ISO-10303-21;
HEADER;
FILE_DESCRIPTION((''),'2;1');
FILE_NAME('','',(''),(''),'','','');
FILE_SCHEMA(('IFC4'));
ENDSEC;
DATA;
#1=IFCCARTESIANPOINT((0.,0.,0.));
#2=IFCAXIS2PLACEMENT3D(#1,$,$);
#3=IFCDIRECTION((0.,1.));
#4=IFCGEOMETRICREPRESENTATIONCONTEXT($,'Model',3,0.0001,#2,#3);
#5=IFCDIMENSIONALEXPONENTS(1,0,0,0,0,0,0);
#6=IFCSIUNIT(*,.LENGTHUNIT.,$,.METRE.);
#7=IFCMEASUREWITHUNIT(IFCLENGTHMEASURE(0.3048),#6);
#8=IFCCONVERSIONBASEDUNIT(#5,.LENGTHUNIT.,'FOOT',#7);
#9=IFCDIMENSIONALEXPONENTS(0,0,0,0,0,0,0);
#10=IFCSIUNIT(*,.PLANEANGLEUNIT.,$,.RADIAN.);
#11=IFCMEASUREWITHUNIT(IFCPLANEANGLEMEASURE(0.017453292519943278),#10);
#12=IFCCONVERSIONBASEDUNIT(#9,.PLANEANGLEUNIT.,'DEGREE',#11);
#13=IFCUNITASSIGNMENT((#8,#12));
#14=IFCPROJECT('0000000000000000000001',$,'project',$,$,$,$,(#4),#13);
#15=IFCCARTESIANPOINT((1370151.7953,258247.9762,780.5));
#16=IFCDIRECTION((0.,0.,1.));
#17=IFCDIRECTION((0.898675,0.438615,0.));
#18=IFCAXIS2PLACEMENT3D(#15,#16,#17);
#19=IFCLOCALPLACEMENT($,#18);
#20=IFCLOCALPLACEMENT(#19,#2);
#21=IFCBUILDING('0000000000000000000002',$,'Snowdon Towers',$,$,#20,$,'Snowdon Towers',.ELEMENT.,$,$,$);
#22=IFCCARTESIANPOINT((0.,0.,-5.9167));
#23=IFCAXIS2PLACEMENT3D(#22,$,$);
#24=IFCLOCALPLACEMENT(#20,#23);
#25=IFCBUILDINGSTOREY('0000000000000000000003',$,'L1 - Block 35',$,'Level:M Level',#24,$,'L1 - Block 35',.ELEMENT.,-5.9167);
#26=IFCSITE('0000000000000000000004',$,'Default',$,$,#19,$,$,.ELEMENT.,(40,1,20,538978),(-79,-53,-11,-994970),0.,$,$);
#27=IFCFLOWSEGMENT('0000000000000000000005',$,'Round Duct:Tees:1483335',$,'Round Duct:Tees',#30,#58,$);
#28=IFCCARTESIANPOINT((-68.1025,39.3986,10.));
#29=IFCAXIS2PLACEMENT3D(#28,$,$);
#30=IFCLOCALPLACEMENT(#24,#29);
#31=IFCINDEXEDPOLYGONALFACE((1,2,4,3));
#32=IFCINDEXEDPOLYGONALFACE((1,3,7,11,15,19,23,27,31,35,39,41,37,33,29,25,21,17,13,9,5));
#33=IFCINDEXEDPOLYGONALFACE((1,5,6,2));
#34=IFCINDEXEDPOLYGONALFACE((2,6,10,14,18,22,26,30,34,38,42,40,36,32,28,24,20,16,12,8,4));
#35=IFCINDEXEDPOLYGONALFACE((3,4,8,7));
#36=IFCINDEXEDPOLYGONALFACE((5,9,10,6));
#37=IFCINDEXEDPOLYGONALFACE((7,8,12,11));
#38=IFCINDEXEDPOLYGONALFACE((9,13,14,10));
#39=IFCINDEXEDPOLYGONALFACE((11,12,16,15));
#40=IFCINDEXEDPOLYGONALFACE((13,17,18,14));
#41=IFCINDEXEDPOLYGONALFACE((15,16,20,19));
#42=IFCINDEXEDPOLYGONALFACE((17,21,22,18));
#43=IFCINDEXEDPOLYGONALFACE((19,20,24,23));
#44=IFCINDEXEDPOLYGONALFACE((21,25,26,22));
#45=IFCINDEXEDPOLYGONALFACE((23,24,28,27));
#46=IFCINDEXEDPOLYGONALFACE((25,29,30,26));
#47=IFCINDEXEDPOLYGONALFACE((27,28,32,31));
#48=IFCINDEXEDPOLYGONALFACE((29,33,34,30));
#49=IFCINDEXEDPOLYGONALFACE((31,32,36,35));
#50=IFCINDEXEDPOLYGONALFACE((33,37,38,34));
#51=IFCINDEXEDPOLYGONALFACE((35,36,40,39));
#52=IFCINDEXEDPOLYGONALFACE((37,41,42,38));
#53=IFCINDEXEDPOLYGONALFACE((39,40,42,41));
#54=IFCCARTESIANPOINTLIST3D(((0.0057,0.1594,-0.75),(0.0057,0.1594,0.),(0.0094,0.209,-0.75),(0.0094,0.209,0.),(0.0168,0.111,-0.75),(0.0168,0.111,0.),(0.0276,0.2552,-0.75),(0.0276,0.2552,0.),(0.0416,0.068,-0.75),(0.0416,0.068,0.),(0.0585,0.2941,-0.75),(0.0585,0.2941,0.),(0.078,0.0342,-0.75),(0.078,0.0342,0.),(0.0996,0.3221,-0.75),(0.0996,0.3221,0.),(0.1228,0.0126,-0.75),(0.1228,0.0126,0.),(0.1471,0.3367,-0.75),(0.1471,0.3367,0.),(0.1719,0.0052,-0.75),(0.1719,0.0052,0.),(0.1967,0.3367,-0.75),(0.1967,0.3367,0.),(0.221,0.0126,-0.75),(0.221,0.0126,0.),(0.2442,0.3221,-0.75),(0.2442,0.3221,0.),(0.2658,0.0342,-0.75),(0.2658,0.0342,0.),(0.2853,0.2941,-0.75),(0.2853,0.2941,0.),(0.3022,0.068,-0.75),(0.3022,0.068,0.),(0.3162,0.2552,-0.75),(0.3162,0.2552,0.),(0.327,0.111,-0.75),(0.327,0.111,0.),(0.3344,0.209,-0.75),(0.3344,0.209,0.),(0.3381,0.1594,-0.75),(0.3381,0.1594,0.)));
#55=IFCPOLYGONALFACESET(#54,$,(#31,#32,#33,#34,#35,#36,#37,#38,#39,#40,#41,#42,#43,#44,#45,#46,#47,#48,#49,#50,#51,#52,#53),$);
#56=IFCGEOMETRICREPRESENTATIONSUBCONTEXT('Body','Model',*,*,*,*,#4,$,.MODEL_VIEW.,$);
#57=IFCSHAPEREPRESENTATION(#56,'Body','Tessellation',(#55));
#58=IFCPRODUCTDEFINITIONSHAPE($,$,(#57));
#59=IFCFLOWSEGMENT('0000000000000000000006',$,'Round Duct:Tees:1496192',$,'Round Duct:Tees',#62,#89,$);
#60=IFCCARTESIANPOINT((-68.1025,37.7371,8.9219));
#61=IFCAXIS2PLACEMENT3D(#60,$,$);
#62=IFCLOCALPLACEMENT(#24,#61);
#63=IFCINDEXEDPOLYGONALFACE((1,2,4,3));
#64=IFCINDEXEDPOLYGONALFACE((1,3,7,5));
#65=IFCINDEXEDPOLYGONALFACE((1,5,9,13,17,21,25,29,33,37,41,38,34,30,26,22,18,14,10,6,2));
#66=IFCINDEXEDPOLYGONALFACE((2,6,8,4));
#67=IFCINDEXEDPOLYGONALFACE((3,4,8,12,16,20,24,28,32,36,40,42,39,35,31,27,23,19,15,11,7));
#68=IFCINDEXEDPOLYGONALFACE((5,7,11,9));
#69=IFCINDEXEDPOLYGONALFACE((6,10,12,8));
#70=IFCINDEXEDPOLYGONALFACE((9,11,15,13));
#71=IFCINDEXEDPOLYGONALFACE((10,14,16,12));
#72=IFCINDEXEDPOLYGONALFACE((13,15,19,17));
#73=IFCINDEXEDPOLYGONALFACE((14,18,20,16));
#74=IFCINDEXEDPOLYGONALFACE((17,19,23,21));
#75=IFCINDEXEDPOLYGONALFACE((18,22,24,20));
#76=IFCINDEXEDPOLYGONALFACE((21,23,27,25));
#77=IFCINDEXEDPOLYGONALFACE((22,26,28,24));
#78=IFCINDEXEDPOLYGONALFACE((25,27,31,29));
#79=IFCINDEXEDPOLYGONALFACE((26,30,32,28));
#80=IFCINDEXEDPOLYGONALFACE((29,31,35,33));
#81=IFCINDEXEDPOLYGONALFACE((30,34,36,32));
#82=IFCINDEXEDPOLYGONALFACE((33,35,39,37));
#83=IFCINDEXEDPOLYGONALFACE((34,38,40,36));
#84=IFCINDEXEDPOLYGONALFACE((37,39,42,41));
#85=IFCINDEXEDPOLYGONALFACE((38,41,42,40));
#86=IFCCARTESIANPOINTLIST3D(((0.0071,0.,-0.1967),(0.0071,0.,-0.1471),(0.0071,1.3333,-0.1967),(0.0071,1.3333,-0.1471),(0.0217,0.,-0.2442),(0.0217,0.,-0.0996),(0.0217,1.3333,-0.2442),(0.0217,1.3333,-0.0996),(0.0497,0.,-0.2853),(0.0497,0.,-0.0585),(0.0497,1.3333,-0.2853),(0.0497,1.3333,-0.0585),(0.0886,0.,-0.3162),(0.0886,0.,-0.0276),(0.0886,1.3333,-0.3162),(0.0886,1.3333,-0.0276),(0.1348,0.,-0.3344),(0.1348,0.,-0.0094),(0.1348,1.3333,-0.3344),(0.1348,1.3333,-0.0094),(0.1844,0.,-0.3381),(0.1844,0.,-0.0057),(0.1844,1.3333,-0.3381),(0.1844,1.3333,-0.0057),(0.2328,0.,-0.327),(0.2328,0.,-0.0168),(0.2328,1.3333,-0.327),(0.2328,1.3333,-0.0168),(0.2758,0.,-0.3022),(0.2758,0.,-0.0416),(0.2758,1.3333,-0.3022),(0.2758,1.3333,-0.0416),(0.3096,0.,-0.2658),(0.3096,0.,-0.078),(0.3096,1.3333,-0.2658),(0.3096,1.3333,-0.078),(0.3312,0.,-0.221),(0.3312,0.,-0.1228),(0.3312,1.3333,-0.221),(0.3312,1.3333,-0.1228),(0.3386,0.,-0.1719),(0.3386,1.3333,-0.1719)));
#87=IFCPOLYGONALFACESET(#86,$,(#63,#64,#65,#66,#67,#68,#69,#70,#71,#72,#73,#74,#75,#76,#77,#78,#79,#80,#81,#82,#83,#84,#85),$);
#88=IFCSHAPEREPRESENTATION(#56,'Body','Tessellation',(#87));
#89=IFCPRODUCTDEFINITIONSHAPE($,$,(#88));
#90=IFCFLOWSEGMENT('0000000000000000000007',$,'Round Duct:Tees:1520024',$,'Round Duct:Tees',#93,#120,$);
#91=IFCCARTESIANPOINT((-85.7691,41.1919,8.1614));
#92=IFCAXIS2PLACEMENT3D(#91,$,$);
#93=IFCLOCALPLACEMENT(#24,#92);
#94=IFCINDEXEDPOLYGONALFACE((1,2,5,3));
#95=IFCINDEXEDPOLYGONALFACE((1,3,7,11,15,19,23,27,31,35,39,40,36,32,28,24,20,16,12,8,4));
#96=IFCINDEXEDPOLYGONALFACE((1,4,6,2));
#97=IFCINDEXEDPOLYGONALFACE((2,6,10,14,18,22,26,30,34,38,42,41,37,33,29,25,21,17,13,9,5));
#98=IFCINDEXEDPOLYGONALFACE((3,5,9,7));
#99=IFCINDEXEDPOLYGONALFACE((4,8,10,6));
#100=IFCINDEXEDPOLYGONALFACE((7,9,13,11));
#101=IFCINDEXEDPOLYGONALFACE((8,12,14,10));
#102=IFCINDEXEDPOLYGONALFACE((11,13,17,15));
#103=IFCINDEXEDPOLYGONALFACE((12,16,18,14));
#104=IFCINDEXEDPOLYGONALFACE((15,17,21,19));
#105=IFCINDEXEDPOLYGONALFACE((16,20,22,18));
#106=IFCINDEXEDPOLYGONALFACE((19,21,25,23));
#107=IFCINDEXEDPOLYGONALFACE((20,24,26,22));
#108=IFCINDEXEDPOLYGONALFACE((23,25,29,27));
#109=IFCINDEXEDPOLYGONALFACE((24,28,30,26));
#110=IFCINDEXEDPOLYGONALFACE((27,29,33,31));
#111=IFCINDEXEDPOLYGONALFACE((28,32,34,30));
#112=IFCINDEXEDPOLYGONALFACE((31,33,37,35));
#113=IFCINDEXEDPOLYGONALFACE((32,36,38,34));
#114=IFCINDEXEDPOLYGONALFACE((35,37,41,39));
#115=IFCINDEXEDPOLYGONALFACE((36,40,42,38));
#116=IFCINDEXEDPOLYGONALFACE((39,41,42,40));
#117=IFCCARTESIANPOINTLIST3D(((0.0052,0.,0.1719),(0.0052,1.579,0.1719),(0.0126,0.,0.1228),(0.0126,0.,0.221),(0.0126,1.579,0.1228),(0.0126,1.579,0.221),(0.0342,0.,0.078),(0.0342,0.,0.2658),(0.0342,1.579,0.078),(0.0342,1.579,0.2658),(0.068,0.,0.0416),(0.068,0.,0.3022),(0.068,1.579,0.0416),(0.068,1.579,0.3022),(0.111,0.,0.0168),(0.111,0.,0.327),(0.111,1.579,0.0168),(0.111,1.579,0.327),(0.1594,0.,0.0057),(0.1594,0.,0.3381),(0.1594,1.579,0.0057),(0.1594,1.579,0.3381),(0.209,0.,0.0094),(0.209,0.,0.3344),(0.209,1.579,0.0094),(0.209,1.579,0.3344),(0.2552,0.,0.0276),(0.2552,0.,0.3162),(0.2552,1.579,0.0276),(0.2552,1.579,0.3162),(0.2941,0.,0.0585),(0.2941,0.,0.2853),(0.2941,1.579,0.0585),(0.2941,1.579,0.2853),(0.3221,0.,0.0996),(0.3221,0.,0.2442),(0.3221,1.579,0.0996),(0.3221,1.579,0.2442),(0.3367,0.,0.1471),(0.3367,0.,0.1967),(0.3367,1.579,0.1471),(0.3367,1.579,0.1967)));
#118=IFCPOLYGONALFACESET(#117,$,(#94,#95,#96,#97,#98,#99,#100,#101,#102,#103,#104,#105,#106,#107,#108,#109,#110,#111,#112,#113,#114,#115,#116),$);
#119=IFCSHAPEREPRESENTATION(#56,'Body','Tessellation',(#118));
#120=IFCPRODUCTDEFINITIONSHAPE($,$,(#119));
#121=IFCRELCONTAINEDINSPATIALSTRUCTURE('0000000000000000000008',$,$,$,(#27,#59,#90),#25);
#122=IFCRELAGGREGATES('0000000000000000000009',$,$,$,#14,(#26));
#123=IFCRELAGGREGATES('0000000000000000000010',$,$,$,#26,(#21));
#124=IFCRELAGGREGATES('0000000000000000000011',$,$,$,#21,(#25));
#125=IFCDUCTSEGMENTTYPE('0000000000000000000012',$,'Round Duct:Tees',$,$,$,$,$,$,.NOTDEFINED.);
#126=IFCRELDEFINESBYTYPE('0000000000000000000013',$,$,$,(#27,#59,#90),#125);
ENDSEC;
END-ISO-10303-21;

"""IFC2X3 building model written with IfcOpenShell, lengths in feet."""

from ifc_helpers import new_model, entity, si_unit, converted_unit, direction, frame, origin, origin_2d_with_axis, place, context, subcontext, project, spatial, circle, extrude, type_object, element, save


model = new_model("IFC2X3")

# Units and contexts
model_context = context("Model", 3, precision=0.0001, world=origin(), true_north=direction((0.0, 1.0)))
body_context = subcontext(model_context, "Body", "Model", "MODEL_VIEW")
ifc_project = project(units=[converted_unit("LENGTHUNIT", "FOOT", entity("IfcLengthMeasure", 0.3048), si_unit("LENGTHUNIT", "METRE"), dimensions=[1, 0, 0, 0, 0, 0, 0]), converted_unit("PLANEANGLEUNIT", "DEGREE", entity("IfcPlaneAngleMeasure", 0.017453292519943278), si_unit("PLANEANGLEUNIT", "RADIAN"), dimensions=[0, 0, 0, 0, 0, 0, 0])], contexts=[model_context])

# Site, building, storey
site_placement = place(None, frame((1370151.7953, 258247.9762, 780.5), z_axis=(0.0, 0.0, 1.0), x_axis=(0.898675, 0.438615, 0.0)))
site = spatial("IfcSite", under=ifc_project, at=site_placement, Name="Default", CompositionType="ELEMENT", RefLatitude=(40, 1, 20, 538978), RefLongitude=(-79, -53, -11, -994970), RefElevation=0.0)
building_placement = place(site_placement, origin())
building = spatial("IfcBuilding", under=site, at=building_placement, Name="Snowdon Towers", LongName="Snowdon Towers", CompositionType="ELEMENT")
storey_placement = place(building_placement, frame((0.0, 0.0, -5.9167)))
storey = spatial("IfcBuildingStorey", under=building, at=storey_placement, Name="L1 - Block 35", ObjectType="Level:M Level", LongName="L1 - Block 35", CompositionType="ELEMENT", Elevation=-5.9167)

# Flow segments
duct_segment_type = type_object("IfcDuctSegmentType", Name="Round Duct:Tees", PredefinedType="NOTDEFINED")
flow_segment_1_placement = place(storey_placement, frame((-68.1025, 39.3986, 10.0)))
element("IfcFlowSegment", 1, at=flow_segment_1_placement, inside=storey, type_object=duct_segment_type, Name="Round Duct:Tees:1483335", ObjectType="Round Duct:Tees", context=body_context, shape_type="SweptSolid", body=[
    extrude(circle(Radius=0.1667, at=origin_2d_with_axis()), frame((0.1719, 0.1719, -0.75), z_axis=(0.0, 0.0, 1.0), x_axis=(0.0, -1.0, 0.0)), (0.0, 0.0, 1.0), 0.75),
])
flow_segment_2_placement = place(storey_placement, frame((-68.1025, 37.7371, 8.9219)))
element("IfcFlowSegment", 2, at=flow_segment_2_placement, inside=storey, type_object=duct_segment_type, Name="Round Duct:Tees:1496192", ObjectType="Round Duct:Tees", context=body_context, shape_type="SweptSolid", body=[
    extrude(circle(Radius=0.1667, at=origin_2d_with_axis()), frame((0.1719, 0.0, -0.1719), z_axis=(0.0, 1.0, 0.0), x_axis=(1.0, 0.0, 0.0)), (0.0, 0.0, 1.0), 1.3333),
])
flow_segment_3_placement = place(storey_placement, frame((-85.7691, 41.1919, 8.1614)))
element("IfcFlowSegment", 3, at=flow_segment_3_placement, inside=storey, type_object=duct_segment_type, Name="Round Duct:Tees:1520024", ObjectType="Round Duct:Tees", context=body_context, shape_type="SweptSolid", body=[
    extrude(circle(Radius=0.1667, at=origin_2d_with_axis()), frame((0.1719, 0.0, 0.1719), z_axis=(0.0, 1.0, 0.0), x_axis=(-1.0, 0.0, 0.0)), (0.0, 0.0, 1.0), 1.579),
])

save(model, "model.ifc")
